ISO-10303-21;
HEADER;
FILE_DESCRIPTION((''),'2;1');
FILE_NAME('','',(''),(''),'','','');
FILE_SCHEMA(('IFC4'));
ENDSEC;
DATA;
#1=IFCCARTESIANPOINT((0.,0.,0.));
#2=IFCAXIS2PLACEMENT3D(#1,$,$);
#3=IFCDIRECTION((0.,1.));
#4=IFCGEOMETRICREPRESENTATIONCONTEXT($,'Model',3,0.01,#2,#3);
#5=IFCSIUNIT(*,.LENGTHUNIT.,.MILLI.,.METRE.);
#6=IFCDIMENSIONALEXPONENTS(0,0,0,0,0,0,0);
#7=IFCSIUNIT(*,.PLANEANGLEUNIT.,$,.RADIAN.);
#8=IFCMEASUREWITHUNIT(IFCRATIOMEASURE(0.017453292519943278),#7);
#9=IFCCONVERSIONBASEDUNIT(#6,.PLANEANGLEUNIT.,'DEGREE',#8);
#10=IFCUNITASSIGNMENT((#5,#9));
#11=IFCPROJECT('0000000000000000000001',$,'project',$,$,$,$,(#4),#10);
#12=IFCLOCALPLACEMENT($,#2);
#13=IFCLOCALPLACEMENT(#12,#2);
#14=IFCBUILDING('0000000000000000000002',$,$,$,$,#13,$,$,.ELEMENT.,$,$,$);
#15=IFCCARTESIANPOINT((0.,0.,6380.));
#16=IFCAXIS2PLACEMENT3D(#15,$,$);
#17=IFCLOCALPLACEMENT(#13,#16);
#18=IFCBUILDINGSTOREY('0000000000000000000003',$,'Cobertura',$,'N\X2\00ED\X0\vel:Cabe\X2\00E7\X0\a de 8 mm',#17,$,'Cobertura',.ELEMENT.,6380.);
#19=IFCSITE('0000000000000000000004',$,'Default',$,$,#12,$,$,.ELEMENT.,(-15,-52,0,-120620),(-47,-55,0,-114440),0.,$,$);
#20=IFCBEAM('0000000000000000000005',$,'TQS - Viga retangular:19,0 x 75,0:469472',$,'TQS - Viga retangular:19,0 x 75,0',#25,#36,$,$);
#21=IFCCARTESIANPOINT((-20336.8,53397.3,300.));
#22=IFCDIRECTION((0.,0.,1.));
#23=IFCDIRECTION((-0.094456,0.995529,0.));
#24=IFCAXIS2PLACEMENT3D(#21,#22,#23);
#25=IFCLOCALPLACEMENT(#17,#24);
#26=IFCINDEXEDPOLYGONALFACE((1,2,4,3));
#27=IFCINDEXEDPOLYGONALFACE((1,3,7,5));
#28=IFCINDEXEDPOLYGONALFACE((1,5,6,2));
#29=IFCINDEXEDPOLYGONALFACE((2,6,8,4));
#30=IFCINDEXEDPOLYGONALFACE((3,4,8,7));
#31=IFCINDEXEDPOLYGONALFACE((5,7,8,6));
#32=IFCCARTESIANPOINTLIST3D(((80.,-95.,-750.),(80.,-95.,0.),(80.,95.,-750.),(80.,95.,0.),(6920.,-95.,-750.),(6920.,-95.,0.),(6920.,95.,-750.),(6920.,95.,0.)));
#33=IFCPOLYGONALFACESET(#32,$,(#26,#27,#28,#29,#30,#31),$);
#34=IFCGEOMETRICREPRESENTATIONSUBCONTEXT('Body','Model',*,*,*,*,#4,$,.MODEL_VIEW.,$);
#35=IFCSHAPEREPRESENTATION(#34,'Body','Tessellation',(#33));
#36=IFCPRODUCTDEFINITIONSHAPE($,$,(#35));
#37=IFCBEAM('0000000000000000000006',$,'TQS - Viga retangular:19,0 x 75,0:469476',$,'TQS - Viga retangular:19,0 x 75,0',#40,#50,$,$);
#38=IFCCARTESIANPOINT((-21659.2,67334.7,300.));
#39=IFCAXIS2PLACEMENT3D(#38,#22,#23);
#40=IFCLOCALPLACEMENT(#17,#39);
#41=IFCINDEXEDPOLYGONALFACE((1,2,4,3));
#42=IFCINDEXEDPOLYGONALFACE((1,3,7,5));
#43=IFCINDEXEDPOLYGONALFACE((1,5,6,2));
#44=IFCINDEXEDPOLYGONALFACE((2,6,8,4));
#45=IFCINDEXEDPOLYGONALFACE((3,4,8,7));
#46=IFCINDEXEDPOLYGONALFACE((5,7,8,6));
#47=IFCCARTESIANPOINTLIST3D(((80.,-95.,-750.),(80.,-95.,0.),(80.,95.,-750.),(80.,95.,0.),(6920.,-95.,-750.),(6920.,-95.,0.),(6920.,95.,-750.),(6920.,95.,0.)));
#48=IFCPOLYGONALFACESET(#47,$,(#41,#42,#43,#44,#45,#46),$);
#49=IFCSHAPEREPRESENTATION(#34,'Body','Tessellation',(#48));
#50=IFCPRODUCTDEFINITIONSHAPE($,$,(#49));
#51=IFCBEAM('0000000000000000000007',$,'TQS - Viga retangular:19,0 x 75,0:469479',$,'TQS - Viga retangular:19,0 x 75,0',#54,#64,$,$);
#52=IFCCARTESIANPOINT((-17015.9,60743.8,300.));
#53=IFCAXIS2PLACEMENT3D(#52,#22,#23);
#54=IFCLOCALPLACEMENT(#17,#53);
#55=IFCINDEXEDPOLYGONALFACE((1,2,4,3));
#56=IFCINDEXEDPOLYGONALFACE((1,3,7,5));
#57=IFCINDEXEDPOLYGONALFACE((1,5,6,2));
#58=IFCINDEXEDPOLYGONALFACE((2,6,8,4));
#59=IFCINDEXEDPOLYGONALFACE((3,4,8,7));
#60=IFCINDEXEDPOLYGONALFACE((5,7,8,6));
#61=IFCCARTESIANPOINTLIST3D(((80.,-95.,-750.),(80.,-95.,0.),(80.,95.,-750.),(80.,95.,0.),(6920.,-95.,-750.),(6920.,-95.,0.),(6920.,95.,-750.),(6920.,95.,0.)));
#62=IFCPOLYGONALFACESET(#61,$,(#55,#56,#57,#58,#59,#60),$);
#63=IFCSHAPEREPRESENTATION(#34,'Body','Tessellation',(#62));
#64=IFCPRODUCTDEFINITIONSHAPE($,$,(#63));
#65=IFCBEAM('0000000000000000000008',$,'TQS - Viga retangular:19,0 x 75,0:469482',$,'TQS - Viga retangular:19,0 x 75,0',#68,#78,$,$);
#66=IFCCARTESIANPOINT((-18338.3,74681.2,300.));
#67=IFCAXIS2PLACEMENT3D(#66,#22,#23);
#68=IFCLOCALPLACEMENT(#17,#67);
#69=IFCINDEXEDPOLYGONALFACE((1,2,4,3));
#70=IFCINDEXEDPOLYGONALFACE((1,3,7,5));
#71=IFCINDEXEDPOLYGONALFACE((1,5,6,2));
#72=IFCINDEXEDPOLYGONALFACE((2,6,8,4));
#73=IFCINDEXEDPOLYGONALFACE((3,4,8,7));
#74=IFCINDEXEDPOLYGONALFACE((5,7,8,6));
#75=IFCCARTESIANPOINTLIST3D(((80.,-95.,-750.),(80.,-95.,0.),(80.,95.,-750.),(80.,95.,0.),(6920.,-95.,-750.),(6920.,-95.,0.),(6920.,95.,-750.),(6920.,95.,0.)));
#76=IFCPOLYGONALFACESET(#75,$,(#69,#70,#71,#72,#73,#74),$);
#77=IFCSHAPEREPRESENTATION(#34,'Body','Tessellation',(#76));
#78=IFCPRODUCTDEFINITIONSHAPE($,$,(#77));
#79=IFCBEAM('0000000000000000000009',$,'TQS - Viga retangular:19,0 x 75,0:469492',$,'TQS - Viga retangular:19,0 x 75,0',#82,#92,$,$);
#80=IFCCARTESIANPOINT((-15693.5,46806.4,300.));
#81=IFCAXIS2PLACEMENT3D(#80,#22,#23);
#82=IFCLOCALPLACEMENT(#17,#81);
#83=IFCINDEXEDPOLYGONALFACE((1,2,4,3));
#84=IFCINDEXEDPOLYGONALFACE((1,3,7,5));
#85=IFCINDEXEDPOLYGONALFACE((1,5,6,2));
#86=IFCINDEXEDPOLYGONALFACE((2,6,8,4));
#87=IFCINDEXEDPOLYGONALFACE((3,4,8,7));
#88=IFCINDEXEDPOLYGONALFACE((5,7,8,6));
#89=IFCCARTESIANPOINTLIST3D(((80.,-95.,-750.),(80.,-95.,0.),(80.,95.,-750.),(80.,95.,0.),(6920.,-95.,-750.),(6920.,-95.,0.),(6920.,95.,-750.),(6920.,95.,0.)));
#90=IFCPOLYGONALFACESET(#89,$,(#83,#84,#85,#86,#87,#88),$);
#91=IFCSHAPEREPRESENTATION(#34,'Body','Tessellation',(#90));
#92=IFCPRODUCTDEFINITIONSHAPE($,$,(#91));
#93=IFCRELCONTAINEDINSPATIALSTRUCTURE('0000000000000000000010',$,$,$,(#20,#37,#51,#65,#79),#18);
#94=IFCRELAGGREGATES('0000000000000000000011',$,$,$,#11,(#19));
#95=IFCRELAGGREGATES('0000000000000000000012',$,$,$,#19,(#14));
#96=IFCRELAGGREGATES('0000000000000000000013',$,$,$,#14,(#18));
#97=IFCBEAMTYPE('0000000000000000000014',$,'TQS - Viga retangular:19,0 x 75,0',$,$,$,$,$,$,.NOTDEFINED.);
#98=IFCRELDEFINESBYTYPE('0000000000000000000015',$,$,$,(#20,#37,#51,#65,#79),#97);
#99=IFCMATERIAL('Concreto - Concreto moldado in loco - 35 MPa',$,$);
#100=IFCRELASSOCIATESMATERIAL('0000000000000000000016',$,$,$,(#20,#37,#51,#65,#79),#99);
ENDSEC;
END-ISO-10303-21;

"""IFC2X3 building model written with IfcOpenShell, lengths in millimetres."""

from ifc_helpers import new_model, entity, si_unit, converted_unit, direction, frame, frame_2d, origin, place, context, subcontext, project, spatial, rectangle, extrude, material, type_object, element, save


model = new_model("IFC2X3")

# Units and contexts
model_context = context("Model", 3, precision=0.01, world=origin(), true_north=direction((0.0, 1.0)))
body_context = subcontext(model_context, "Body", "Model", "MODEL_VIEW")
ifc_project = project(units=[si_unit("LENGTHUNIT", "METRE", prefix="MILLI"), converted_unit("PLANEANGLEUNIT", "DEGREE", entity("IfcRatioMeasure", 0.017453292519943278), si_unit("PLANEANGLEUNIT", "RADIAN"), dimensions=[0, 0, 0, 0, 0, 0, 0])], contexts=[model_context])

# Site, building, storey
site_placement = place(None, origin())
site = spatial("IfcSite", under=ifc_project, at=site_placement, Name="Default", CompositionType="ELEMENT", RefLatitude=(-15, -52, 0, -120620), RefLongitude=(-47, -55, 0, -114440), RefElevation=0.0)
building_placement = place(site_placement, origin())
building = spatial("IfcBuilding", under=site, at=building_placement, CompositionType="ELEMENT")
storey_placement = place(building_placement, frame((0.0, 0.0, 6380.0)))
storey = spatial("IfcBuildingStorey", under=building, at=storey_placement, Name="Cobertura", ObjectType="Nível:Cabeça de 8 mm", LongName="Cobertura", CompositionType="ELEMENT", Elevation=6380.0)

# Beams
ifc_material = material(Name="Concreto - Concreto moldado in loco - 35 MPa")
beam_type_1 = type_object("IfcBeamType", Name="TQS - Viga retangular:19,0 x 75,0", PredefinedType="NOTDEFINED")
beam_1_placement = place(storey_placement, frame((-20336.8, 53397.3, 300.0), z_axis=(0.0, 0.0, 1.0), x_axis=(-0.094456, 0.995529, 0.0)))
element("IfcBeam", 1, at=beam_1_placement, inside=storey, type_object=beam_type_1, material=ifc_material, Name="TQS - Viga retangular:19,0 x 75,0:469472", ObjectType="TQS - Viga retangular:19,0 x 75,0", context=body_context, shape_type="SweptSolid", body=[
    extrude(rectangle(XDim=750.0, YDim=190.0, at=frame_2d((0.0, 0.0), x_axis=(1.0, 0.0))), frame((80.0, 0.0, -375.0), z_axis=(1.0, 0.0, 0.0), x_axis=(0.0, 0.0, -1.0)), (0.0, 0.0, 1.0), 6840.0),
])
beam_2_placement = place(storey_placement, frame((-21659.2, 67334.7, 300.0), z_axis=(0.0, 0.0, 1.0), x_axis=(-0.094456, 0.995529, 0.0)))
element("IfcBeam", 2, at=beam_2_placement, inside=storey, type_object=beam_type_1, material=ifc_material, Name="TQS - Viga retangular:19,0 x 75,0:469476", ObjectType="TQS - Viga retangular:19,0 x 75,0", context=body_context, shape_type="SweptSolid", body=[
    extrude(rectangle(XDim=750.0, YDim=190.0, at=frame_2d((0.0, 0.0), x_axis=(1.0, 0.0))), frame((80.0, 0.0, -375.0), z_axis=(1.0, 0.0, 0.0), x_axis=(0.0, 0.0, -1.0)), (0.0, 0.0, 1.0), 6840.0),
])
beam_3_placement = place(storey_placement, frame((-17015.9, 60743.8, 300.0), z_axis=(0.0, 0.0, 1.0), x_axis=(-0.094456, 0.995529, 0.0)))
element("IfcBeam", 3, at=beam_3_placement, inside=storey, type_object=beam_type_1, material=ifc_material, Name="TQS - Viga retangular:19,0 x 75,0:469479", ObjectType="TQS - Viga retangular:19,0 x 75,0", context=body_context, shape_type="SweptSolid", body=[
    extrude(rectangle(XDim=750.0, YDim=190.0, at=frame_2d((0.0, 0.0), x_axis=(1.0, 0.0))), frame((80.0, 0.0, -375.0), z_axis=(1.0, 0.0, 0.0), x_axis=(0.0, 0.0, -1.0)), (0.0, 0.0, 1.0), 6840.0),
])
beam_4_placement = place(storey_placement, frame((-18338.3, 74681.2, 300.0), z_axis=(0.0, 0.0, 1.0), x_axis=(-0.094456, 0.995529, 0.0)))
element("IfcBeam", 4, at=beam_4_placement, inside=storey, type_object=beam_type_1, material=ifc_material, Name="TQS - Viga retangular:19,0 x 75,0:469482", ObjectType="TQS - Viga retangular:19,0 x 75,0", context=body_context, shape_type="SweptSolid", body=[
    extrude(rectangle(XDim=750.0, YDim=190.0, at=frame_2d((0.0, 0.0), x_axis=(1.0, 0.0))), frame((80.0, 0.0, -375.0), z_axis=(1.0, 0.0, 0.0), x_axis=(0.0, 0.0, -1.0)), (0.0, 0.0, 1.0), 6840.0),
])
beam_5_placement = place(storey_placement, frame((-15693.5, 46806.4, 300.0), z_axis=(0.0, 0.0, 1.0), x_axis=(-0.094456, 0.995529, 0.0)))
element("IfcBeam", 5, at=beam_5_placement, inside=storey, type_object=beam_type_1, material=ifc_material, Name="TQS - Viga retangular:19,0 x 75,0:469492", ObjectType="TQS - Viga retangular:19,0 x 75,0", context=body_context, shape_type="SweptSolid", body=[
    extrude(rectangle(XDim=750.0, YDim=190.0, at=frame_2d((0.0, 0.0), x_axis=(1.0, 0.0))), frame((80.0, 0.0, -375.0), z_axis=(1.0, 0.0, 0.0), x_axis=(0.0, 0.0, -1.0)), (0.0, 0.0, 1.0), 6840.0),
])

save(model, "model.ifc")
